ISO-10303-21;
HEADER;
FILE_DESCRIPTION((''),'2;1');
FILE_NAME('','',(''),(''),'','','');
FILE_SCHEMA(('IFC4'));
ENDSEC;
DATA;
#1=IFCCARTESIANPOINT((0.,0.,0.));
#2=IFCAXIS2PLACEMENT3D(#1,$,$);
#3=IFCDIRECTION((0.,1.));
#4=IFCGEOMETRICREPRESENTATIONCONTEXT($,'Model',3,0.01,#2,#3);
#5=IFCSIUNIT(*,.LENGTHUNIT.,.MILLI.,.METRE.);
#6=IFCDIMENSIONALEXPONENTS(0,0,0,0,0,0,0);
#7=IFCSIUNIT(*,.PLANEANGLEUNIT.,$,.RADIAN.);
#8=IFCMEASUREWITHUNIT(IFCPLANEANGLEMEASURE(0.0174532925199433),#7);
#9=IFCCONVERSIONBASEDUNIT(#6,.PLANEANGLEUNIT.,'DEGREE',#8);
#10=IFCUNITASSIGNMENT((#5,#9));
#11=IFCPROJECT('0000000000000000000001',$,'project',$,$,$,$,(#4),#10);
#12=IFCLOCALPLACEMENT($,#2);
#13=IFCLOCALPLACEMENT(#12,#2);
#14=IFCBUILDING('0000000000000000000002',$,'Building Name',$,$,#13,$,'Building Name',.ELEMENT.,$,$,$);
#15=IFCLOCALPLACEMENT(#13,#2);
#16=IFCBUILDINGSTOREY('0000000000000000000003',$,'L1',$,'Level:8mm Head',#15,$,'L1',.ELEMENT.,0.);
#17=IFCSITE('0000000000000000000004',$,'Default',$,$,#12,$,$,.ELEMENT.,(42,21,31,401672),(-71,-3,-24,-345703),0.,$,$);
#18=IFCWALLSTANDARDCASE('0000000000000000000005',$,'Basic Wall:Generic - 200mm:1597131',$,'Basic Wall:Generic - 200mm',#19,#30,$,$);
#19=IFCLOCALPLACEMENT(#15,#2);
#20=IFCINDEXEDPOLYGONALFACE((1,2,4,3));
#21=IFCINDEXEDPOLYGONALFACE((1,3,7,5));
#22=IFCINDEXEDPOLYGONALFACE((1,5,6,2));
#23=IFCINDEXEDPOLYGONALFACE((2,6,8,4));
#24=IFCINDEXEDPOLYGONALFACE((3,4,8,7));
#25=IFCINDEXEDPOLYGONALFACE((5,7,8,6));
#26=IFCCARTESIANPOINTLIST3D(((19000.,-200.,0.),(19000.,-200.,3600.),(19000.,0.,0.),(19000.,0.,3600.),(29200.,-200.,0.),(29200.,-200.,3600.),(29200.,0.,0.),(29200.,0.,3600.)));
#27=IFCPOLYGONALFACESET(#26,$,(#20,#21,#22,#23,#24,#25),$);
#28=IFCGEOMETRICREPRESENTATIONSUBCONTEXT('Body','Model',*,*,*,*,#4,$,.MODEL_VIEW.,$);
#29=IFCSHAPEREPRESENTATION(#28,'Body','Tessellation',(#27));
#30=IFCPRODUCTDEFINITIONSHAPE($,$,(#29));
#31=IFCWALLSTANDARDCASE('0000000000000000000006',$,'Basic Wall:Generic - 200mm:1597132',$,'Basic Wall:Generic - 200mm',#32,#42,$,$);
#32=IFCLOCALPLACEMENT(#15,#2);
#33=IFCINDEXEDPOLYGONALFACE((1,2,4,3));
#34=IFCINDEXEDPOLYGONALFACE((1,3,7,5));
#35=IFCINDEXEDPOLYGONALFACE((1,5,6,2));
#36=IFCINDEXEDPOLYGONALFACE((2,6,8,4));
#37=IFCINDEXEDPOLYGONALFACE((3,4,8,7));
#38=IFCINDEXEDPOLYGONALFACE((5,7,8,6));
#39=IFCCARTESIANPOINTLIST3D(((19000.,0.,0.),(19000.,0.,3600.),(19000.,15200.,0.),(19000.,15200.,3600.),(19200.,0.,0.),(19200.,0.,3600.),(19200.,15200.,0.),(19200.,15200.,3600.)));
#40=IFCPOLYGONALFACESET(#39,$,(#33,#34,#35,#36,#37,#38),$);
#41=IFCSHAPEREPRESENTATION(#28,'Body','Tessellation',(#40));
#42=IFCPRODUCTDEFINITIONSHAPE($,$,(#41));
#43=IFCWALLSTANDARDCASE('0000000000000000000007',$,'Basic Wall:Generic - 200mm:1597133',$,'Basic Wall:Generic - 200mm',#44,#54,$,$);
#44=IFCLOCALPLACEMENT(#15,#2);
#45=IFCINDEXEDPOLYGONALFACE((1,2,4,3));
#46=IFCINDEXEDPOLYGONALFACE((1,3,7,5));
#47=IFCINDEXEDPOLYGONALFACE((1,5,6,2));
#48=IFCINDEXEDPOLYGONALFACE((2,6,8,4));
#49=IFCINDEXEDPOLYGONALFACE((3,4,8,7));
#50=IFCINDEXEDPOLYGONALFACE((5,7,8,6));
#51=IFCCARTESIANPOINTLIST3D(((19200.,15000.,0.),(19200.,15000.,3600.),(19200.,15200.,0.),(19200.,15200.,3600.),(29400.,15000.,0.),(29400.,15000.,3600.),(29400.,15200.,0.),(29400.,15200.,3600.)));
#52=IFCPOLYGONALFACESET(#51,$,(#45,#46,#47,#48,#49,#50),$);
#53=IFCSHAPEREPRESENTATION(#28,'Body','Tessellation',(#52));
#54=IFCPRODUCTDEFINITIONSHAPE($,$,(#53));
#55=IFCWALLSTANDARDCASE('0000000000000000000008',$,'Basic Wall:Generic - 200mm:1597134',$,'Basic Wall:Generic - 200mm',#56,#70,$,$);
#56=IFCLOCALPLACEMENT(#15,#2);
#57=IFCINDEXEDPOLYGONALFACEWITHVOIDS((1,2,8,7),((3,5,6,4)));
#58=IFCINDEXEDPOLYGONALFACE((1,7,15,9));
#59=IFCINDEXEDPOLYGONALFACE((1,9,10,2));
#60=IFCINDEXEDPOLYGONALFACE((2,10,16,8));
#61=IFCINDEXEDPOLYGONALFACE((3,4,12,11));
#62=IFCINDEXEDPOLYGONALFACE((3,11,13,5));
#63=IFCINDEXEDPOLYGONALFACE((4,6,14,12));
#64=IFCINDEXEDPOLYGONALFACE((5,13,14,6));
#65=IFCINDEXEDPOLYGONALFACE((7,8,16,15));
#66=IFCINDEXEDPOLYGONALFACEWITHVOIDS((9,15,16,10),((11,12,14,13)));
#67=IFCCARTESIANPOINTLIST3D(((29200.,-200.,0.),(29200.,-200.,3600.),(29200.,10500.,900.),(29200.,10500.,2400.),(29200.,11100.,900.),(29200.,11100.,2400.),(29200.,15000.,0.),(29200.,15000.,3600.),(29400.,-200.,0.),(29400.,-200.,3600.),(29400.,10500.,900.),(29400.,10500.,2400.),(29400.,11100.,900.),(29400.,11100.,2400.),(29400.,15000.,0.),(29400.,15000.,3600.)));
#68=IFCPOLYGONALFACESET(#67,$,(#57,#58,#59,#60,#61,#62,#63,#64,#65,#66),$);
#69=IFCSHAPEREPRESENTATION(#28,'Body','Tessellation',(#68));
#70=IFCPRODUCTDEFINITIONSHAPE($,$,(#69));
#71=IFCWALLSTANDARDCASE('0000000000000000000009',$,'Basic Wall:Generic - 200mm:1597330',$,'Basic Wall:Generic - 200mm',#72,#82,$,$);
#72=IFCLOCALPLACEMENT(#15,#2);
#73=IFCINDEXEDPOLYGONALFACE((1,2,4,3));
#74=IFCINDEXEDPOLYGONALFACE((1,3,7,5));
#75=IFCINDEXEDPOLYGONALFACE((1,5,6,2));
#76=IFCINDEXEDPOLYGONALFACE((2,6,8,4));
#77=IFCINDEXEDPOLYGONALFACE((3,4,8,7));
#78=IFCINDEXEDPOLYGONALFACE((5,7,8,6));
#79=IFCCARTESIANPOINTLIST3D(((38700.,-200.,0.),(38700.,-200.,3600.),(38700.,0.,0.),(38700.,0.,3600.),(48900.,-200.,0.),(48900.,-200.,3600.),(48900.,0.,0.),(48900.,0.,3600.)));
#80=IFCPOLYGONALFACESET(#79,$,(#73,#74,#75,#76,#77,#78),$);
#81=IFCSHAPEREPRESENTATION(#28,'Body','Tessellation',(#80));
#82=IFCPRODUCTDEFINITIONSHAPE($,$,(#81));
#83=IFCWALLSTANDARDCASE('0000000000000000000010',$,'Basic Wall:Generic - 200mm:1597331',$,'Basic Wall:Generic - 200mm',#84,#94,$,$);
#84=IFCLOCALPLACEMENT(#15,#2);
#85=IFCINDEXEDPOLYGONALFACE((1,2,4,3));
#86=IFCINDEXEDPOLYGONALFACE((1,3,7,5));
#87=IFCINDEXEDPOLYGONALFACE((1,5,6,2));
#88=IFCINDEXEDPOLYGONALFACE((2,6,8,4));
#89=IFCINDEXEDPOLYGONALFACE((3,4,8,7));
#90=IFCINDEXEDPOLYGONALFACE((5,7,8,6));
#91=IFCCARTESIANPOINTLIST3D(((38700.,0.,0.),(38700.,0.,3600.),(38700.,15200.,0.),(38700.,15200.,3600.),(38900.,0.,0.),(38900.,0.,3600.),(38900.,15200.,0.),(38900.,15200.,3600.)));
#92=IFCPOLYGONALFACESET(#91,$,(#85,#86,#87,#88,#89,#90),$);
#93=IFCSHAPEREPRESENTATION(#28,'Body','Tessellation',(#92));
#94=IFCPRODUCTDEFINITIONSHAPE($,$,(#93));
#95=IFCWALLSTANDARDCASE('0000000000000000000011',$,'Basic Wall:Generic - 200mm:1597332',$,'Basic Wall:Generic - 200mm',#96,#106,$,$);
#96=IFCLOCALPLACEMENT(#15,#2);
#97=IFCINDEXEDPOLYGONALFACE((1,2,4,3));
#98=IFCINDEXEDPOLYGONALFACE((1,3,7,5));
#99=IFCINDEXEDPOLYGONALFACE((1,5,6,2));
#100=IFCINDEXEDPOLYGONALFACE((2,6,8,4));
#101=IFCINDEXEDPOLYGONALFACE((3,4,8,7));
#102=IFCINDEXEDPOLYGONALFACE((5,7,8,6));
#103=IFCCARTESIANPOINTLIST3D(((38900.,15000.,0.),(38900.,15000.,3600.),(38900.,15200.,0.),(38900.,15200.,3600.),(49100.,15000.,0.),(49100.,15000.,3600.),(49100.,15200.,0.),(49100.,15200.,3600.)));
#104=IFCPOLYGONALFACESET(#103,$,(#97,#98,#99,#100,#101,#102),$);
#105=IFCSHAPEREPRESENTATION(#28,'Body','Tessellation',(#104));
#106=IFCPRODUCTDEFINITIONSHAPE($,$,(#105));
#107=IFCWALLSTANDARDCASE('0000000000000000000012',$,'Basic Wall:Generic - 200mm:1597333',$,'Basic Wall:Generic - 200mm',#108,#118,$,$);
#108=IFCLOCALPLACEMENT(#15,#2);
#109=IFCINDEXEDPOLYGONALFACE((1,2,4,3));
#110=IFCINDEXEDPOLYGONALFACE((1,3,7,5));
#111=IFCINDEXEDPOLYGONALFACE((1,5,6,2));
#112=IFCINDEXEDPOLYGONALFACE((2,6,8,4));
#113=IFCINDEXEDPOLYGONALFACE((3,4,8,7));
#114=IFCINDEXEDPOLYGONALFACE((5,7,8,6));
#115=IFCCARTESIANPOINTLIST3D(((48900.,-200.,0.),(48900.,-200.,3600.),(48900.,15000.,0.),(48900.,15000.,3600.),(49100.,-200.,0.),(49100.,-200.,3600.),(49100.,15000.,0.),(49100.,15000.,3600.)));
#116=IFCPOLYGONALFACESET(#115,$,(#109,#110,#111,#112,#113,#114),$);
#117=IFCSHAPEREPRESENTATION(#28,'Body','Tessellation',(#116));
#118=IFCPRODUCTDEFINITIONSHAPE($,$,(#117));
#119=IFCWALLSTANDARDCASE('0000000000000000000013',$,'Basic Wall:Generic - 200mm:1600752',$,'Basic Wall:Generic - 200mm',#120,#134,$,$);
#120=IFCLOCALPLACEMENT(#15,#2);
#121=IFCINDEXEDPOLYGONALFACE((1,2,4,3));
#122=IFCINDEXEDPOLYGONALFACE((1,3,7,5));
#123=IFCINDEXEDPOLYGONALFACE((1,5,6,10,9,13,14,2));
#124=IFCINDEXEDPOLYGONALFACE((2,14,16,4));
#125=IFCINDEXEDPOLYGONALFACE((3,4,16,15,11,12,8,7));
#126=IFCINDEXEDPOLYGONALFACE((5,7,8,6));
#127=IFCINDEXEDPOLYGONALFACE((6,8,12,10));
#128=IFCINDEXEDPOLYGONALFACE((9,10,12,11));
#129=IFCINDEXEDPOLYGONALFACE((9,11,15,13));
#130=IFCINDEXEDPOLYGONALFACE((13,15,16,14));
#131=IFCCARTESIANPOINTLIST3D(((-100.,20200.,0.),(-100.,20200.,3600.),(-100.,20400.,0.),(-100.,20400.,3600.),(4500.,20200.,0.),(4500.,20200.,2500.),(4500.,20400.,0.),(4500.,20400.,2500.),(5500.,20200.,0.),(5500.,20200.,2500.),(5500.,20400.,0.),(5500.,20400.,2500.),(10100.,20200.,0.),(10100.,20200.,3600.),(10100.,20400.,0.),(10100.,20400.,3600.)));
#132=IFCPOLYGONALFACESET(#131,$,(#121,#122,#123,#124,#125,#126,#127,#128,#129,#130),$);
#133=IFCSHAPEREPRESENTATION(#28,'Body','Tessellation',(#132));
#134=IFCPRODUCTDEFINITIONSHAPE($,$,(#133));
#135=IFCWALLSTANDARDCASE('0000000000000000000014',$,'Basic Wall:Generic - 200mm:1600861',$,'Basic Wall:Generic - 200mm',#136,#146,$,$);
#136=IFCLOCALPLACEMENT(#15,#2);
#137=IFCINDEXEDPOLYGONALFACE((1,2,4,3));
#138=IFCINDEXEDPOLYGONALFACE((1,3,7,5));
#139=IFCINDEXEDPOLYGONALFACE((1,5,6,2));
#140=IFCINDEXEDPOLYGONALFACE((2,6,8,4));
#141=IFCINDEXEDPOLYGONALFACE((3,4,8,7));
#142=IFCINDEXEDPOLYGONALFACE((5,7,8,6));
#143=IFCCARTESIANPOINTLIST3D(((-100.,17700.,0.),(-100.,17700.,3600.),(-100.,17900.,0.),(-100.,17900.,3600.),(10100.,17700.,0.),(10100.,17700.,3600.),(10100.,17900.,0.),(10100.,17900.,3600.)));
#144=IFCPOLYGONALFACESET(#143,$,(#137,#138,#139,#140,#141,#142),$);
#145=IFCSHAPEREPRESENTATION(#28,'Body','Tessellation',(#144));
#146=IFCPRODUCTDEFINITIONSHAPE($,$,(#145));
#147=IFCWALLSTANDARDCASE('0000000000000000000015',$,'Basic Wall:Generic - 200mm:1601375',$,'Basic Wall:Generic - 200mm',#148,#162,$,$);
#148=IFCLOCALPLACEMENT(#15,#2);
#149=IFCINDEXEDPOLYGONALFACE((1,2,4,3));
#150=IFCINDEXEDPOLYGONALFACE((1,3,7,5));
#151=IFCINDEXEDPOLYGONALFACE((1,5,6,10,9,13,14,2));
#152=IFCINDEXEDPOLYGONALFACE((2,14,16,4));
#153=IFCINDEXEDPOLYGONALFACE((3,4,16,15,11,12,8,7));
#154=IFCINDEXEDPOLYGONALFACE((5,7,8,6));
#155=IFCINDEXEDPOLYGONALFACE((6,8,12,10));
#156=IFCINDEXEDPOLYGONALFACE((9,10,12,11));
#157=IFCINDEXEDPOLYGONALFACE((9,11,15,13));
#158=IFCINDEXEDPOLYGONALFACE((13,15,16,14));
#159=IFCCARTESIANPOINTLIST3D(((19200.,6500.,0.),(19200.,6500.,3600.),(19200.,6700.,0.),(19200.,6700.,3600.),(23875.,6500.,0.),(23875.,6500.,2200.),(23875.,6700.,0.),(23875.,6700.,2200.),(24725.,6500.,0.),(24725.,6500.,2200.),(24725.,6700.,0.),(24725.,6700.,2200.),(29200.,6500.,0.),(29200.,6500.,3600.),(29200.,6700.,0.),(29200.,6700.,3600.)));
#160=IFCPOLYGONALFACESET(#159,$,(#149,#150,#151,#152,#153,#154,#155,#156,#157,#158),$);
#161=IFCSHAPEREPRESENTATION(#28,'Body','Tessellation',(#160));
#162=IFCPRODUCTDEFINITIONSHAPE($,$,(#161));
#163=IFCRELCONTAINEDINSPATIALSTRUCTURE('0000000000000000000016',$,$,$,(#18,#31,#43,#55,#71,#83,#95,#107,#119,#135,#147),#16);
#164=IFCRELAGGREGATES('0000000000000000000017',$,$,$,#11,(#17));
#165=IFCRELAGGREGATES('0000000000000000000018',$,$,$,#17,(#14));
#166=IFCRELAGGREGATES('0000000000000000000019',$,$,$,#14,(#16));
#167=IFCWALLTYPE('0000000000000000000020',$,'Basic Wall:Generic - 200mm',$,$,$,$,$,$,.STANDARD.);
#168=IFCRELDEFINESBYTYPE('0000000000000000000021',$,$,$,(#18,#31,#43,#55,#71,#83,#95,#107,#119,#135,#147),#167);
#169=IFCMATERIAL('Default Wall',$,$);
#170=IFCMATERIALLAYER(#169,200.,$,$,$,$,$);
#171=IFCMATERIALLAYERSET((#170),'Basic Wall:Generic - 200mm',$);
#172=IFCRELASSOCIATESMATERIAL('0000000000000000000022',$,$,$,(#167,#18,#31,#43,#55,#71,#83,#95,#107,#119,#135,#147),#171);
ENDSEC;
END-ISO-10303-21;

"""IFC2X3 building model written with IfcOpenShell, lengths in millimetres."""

from ifc_helpers import new_model, entity, si_unit, converted_unit, direction, frame, frame_2d, origin, origin_2d_with_axis, place, context, subcontext, project, spatial, rectangle, extrude, material, layer, layer_set, layer_usage, type_object, element, save


model = new_model("IFC2X3")

# Units and contexts
model_context = context("Model", 3, precision=0.01, world=origin(), true_north=direction((0.0, 1.0)))
body_context = subcontext(model_context, "Body", "Model", "MODEL_VIEW")
ifc_project = project(units=[si_unit("LENGTHUNIT", "METRE", prefix="MILLI"), converted_unit("PLANEANGLEUNIT", "DEGREE", entity("IfcPlaneAngleMeasure", 0.0174532925199433), si_unit("PLANEANGLEUNIT", "RADIAN"), dimensions=[0, 0, 0, 0, 0, 0, 0])], contexts=[model_context])

# Site, building, storey
site_placement = place(None, origin())
site = spatial("IfcSite", under=ifc_project, at=site_placement, Name="Default", CompositionType="ELEMENT", RefLatitude=(42, 21, 31, 401672), RefLongitude=(-71, -3, -24, -345703), RefElevation=0.0)
building_placement = place(site_placement, origin())
building = spatial("IfcBuilding", under=site, at=building_placement, Name="Building Name", LongName="Building Name", CompositionType="ELEMENT")
storey_placement = place(building_placement, origin())
storey = spatial("IfcBuildingStorey", under=building, at=storey_placement, Name="L1", ObjectType="Level:8mm Head", LongName="L1", CompositionType="ELEMENT", Elevation=0.0)

# Walls
ifc_material_1 = material(Name="Default Wall")
ifc_layer_1 = layer(ifc_material_1, 200.0)
ifc_layer_set_1 = layer_set([ifc_layer_1], Name="Basic Wall:Generic - 200mm")
wall_type_1 = type_object("IfcWallType", Name="Basic Wall:Generic - 200mm", PredefinedType="STANDARD", material=ifc_layer_set_1)
ifc_layer_usage_1 = layer_usage(ifc_layer_set_1, "AXIS2", "NEGATIVE", 100.0)
wall_1_placement = place(storey_placement, frame((19000.0, -100.0, 0.0)))
element("IfcWallStandardCase", 1, at=wall_1_placement, inside=storey, type_object=wall_type_1, material=ifc_layer_usage_1, Name="Basic Wall:Generic - 200mm:1597131", ObjectType="Basic Wall:Generic - 200mm", context=body_context, shape_type="SweptSolid", body=[
    extrude(rectangle(XDim=10200.0, YDim=200.0, at=frame_2d((5100.0, 0.0), x_axis=(-1.0, 0.0))), origin(), (0.0, 0.0, 1.0), 3600.0),
])
ifc_layer_usage_2 = layer_usage(ifc_layer_set_1, "AXIS2", "NEGATIVE", 100.0)
wall_2_placement = place(storey_placement, frame((19100.0, 15200.0, 0.0), z_axis=(0.0, 0.0, 1.0), x_axis=(0.0, -1.0, 0.0)))
element("IfcWallStandardCase", 2, at=wall_2_placement, inside=storey, type_object=wall_type_1, material=ifc_layer_usage_2, Name="Basic Wall:Generic - 200mm:1597132", ObjectType="Basic Wall:Generic - 200mm", context=body_context, shape_type="SweptSolid", body=[
    extrude(rectangle(XDim=15200.0, YDim=200.0, at=frame_2d((7600.0, 0.0), x_axis=(-1.0, 0.0))), origin(), (0.0, 0.0, 1.0), 3600.0),
])
ifc_layer_usage_3 = layer_usage(ifc_layer_set_1, "AXIS2", "NEGATIVE", 100.0)
wall_3_placement = place(storey_placement, frame((29400.0, 15100.0, 0.0), z_axis=(0.0, 0.0, 1.0), x_axis=(-1.0, 0.0, 0.0)))
element("IfcWallStandardCase", 3, at=wall_3_placement, inside=storey, type_object=wall_type_1, material=ifc_layer_usage_3, Name="Basic Wall:Generic - 200mm:1597133", ObjectType="Basic Wall:Generic - 200mm", context=body_context, shape_type="SweptSolid", body=[
    extrude(rectangle(XDim=10200.0, YDim=200.0, at=frame_2d((5100.0, 0.0), x_axis=(-1.0, 0.0))), origin(), (0.0, 0.0, 1.0), 3600.0),
])

# Wall, opening
ifc_layer_usage_4 = layer_usage(ifc_layer_set_1, "AXIS2", "NEGATIVE", 100.0)
wall_4_placement = place(storey_placement, frame((29300.0, -200.0, 0.0), z_axis=(0.0, 0.0, 1.0), x_axis=(0.0, 1.0, 0.0)))
wall_4 = element("IfcWallStandardCase", 4, at=wall_4_placement, inside=storey, type_object=wall_type_1, material=ifc_layer_usage_4, Name="Basic Wall:Generic - 200mm:1597134", ObjectType="Basic Wall:Generic - 200mm", context=body_context, shape_type="SweptSolid", body=[
    extrude(rectangle(XDim=15200.0, YDim=200.0, at=frame_2d((7600.0, 0.0), x_axis=(-1.0, 0.0))), origin(), (0.0, 0.0, 1.0), 3600.0),
])
opening_1_placement = place(wall_4_placement, frame((11300.0, 100.0, 900.0)))
element("IfcOpeningElement", 5, at=opening_1_placement, cuts=wall_4, ObjectType="Opening", context=body_context, shape_type="SweptSolid", body=[
    extrude(rectangle(XDim=1500.0, YDim=600.0, at=frame_2d((750.0, 300.0), x_axis=(-1.0, 0.0))), frame((0.0, 0.0, 0.0), z_axis=(0.0, -1.0, 0.0), x_axis=(0.0, 0.0, 1.0)), (0.0, 0.0, 1.0), 200.0),
])

# Walls
ifc_layer_usage_5 = layer_usage(ifc_layer_set_1, "AXIS2", "NEGATIVE", 100.0)
wall_5_placement = place(storey_placement, frame((38700.0, -100.0, 0.0)))
element("IfcWallStandardCase", 6, at=wall_5_placement, inside=storey, type_object=wall_type_1, material=ifc_layer_usage_5, Name="Basic Wall:Generic - 200mm:1597330", ObjectType="Basic Wall:Generic - 200mm", context=body_context, shape_type="SweptSolid", body=[
    extrude(rectangle(XDim=10200.0, YDim=200.0, at=frame_2d((5100.0, 0.0), x_axis=(-1.0, 0.0))), origin(), (0.0, 0.0, 1.0), 3600.0),
])
ifc_layer_usage_6 = layer_usage(ifc_layer_set_1, "AXIS2", "NEGATIVE", 100.0)
wall_6_placement = place(storey_placement, frame((38800.0, 15200.0, 0.0), z_axis=(0.0, 0.0, 1.0), x_axis=(0.0, -1.0, 0.0)))
element("IfcWallStandardCase", 7, at=wall_6_placement, inside=storey, type_object=wall_type_1, material=ifc_layer_usage_6, Name="Basic Wall:Generic - 200mm:1597331", ObjectType="Basic Wall:Generic - 200mm", context=body_context, shape_type="SweptSolid", body=[
    extrude(rectangle(XDim=15200.0, YDim=200.0, at=frame_2d((7600.0, 0.0), x_axis=(-1.0, 0.0))), origin(), (0.0, 0.0, 1.0), 3600.0),
])
ifc_layer_usage_7 = layer_usage(ifc_layer_set_1, "AXIS2", "NEGATIVE", 100.0)
wall_7_placement = place(storey_placement, frame((49100.0, 15100.0, 0.0), z_axis=(0.0, 0.0, 1.0), x_axis=(-1.0, 0.0, 0.0)))
element("IfcWallStandardCase", 8, at=wall_7_placement, inside=storey, type_object=wall_type_1, material=ifc_layer_usage_7, Name="Basic Wall:Generic - 200mm:1597332", ObjectType="Basic Wall:Generic - 200mm", context=body_context, shape_type="SweptSolid", body=[
    extrude(rectangle(XDim=10200.0, YDim=200.0, at=frame_2d((5100.0, 0.0), x_axis=(-1.0, 0.0))), origin(), (0.0, 0.0, 1.0), 3600.0),
])
ifc_layer_usage_8 = layer_usage(ifc_layer_set_1, "AXIS2", "NEGATIVE", 100.0)
wall_8_placement = place(storey_placement, frame((49000.0, -200.0, 0.0), z_axis=(0.0, 0.0, 1.0), x_axis=(0.0, 1.0, 0.0)))
element("IfcWallStandardCase", 9, at=wall_8_placement, inside=storey, type_object=wall_type_1, material=ifc_layer_usage_8, Name="Basic Wall:Generic - 200mm:1597333", ObjectType="Basic Wall:Generic - 200mm", context=body_context, shape_type="SweptSolid", body=[
    extrude(rectangle(XDim=15200.0, YDim=200.0, at=frame_2d((7600.0, 0.0), x_axis=(-1.0, 0.0))), origin(), (0.0, 0.0, 1.0), 3600.0),
])

# Wall, opening
ifc_layer_usage_9 = layer_usage(ifc_layer_set_1, "AXIS2", "NEGATIVE", 100.0)
wall_9_placement = place(storey_placement, frame((10100.0, 20300.0, 0.0), z_axis=(0.0, 0.0, 1.0), x_axis=(-1.0, 0.0, 0.0)))
wall_9 = element("IfcWallStandardCase", 10, at=wall_9_placement, inside=storey, type_object=wall_type_1, material=ifc_layer_usage_9, Name="Basic Wall:Generic - 200mm:1600752", ObjectType="Basic Wall:Generic - 200mm", context=body_context, shape_type="SweptSolid", body=[
    extrude(rectangle(XDim=10200.0, YDim=200.0, at=frame_2d((5100.0, 0.0), x_axis=(1.0, 0.0))), origin(), (0.0, 0.0, 1.0), 3600.0),
])
opening_2_placement = place(wall_9_placement, origin())
element("IfcOpeningElement", 11, at=opening_2_placement, cuts=wall_9, ObjectType="Opening", context=body_context, shape_type="SweptSolid", body=[
    extrude(rectangle(XDim=2500.0, YDim=1000.0, at=origin_2d_with_axis()), frame((5100.0, -100.0, 1250.0), z_axis=(0.0, 1.0, 0.0), x_axis=(0.0, 0.0, -1.0)), (0.0, 0.0, 1.0), 200.0),
])

# Wall
ifc_layer_usage_10 = layer_usage(ifc_layer_set_1, "AXIS2", "NEGATIVE", 100.0)
wall_10_placement = place(storey_placement, frame((10100.0, 17800.0, 0.0), z_axis=(0.0, 0.0, 1.0), x_axis=(-1.0, 0.0, 0.0)))
element("IfcWallStandardCase", 12, at=wall_10_placement, inside=storey, type_object=wall_type_1, material=ifc_layer_usage_10, Name="Basic Wall:Generic - 200mm:1600861", ObjectType="Basic Wall:Generic - 200mm", context=body_context, shape_type="SweptSolid", body=[
    extrude(rectangle(XDim=10200.0, YDim=200.0, at=frame_2d((5100.0, 0.0), x_axis=(-1.0, 0.0))), origin(), (0.0, 0.0, 1.0), 3600.0),
])

# Wall, opening
ifc_layer_usage_11 = layer_usage(ifc_layer_set_1, "AXIS2", "NEGATIVE", 100.0)
wall_11_placement = place(storey_placement, frame((29200.0, 6600.0, 0.0), z_axis=(0.0, 0.0, 1.0), x_axis=(-1.0, 0.0, 0.0)))
wall_11 = element("IfcWallStandardCase", 13, at=wall_11_placement, inside=storey, type_object=wall_type_1, material=ifc_layer_usage_11, Name="Basic Wall:Generic - 200mm:1601375", ObjectType="Basic Wall:Generic - 200mm", context=body_context, shape_type="SweptSolid", body=[
    extrude(rectangle(XDim=10000.0, YDim=200.0, at=frame_2d((5000.0, 0.0), x_axis=(1.0, 0.0))), origin(), (0.0, 0.0, 1.0), 3600.0),
])
opening_3_placement = place(wall_11_placement, frame((5325.0, 100.0, 0.0)))
element("IfcOpeningElement", 14, at=opening_3_placement, cuts=wall_11, ObjectType="Opening", context=body_context, shape_type="SweptSolid", body=[
    extrude(rectangle(XDim=2200.0, YDim=850.0, at=frame_2d((1100.0, 425.0), x_axis=(1.0, 0.0))), frame((0.0, 0.0, 0.0), z_axis=(0.0, -1.0, 0.0), x_axis=(0.0, 0.0, 1.0)), (0.0, 0.0, 1.0), 200.0),
])

save(model, "model.ifc")
